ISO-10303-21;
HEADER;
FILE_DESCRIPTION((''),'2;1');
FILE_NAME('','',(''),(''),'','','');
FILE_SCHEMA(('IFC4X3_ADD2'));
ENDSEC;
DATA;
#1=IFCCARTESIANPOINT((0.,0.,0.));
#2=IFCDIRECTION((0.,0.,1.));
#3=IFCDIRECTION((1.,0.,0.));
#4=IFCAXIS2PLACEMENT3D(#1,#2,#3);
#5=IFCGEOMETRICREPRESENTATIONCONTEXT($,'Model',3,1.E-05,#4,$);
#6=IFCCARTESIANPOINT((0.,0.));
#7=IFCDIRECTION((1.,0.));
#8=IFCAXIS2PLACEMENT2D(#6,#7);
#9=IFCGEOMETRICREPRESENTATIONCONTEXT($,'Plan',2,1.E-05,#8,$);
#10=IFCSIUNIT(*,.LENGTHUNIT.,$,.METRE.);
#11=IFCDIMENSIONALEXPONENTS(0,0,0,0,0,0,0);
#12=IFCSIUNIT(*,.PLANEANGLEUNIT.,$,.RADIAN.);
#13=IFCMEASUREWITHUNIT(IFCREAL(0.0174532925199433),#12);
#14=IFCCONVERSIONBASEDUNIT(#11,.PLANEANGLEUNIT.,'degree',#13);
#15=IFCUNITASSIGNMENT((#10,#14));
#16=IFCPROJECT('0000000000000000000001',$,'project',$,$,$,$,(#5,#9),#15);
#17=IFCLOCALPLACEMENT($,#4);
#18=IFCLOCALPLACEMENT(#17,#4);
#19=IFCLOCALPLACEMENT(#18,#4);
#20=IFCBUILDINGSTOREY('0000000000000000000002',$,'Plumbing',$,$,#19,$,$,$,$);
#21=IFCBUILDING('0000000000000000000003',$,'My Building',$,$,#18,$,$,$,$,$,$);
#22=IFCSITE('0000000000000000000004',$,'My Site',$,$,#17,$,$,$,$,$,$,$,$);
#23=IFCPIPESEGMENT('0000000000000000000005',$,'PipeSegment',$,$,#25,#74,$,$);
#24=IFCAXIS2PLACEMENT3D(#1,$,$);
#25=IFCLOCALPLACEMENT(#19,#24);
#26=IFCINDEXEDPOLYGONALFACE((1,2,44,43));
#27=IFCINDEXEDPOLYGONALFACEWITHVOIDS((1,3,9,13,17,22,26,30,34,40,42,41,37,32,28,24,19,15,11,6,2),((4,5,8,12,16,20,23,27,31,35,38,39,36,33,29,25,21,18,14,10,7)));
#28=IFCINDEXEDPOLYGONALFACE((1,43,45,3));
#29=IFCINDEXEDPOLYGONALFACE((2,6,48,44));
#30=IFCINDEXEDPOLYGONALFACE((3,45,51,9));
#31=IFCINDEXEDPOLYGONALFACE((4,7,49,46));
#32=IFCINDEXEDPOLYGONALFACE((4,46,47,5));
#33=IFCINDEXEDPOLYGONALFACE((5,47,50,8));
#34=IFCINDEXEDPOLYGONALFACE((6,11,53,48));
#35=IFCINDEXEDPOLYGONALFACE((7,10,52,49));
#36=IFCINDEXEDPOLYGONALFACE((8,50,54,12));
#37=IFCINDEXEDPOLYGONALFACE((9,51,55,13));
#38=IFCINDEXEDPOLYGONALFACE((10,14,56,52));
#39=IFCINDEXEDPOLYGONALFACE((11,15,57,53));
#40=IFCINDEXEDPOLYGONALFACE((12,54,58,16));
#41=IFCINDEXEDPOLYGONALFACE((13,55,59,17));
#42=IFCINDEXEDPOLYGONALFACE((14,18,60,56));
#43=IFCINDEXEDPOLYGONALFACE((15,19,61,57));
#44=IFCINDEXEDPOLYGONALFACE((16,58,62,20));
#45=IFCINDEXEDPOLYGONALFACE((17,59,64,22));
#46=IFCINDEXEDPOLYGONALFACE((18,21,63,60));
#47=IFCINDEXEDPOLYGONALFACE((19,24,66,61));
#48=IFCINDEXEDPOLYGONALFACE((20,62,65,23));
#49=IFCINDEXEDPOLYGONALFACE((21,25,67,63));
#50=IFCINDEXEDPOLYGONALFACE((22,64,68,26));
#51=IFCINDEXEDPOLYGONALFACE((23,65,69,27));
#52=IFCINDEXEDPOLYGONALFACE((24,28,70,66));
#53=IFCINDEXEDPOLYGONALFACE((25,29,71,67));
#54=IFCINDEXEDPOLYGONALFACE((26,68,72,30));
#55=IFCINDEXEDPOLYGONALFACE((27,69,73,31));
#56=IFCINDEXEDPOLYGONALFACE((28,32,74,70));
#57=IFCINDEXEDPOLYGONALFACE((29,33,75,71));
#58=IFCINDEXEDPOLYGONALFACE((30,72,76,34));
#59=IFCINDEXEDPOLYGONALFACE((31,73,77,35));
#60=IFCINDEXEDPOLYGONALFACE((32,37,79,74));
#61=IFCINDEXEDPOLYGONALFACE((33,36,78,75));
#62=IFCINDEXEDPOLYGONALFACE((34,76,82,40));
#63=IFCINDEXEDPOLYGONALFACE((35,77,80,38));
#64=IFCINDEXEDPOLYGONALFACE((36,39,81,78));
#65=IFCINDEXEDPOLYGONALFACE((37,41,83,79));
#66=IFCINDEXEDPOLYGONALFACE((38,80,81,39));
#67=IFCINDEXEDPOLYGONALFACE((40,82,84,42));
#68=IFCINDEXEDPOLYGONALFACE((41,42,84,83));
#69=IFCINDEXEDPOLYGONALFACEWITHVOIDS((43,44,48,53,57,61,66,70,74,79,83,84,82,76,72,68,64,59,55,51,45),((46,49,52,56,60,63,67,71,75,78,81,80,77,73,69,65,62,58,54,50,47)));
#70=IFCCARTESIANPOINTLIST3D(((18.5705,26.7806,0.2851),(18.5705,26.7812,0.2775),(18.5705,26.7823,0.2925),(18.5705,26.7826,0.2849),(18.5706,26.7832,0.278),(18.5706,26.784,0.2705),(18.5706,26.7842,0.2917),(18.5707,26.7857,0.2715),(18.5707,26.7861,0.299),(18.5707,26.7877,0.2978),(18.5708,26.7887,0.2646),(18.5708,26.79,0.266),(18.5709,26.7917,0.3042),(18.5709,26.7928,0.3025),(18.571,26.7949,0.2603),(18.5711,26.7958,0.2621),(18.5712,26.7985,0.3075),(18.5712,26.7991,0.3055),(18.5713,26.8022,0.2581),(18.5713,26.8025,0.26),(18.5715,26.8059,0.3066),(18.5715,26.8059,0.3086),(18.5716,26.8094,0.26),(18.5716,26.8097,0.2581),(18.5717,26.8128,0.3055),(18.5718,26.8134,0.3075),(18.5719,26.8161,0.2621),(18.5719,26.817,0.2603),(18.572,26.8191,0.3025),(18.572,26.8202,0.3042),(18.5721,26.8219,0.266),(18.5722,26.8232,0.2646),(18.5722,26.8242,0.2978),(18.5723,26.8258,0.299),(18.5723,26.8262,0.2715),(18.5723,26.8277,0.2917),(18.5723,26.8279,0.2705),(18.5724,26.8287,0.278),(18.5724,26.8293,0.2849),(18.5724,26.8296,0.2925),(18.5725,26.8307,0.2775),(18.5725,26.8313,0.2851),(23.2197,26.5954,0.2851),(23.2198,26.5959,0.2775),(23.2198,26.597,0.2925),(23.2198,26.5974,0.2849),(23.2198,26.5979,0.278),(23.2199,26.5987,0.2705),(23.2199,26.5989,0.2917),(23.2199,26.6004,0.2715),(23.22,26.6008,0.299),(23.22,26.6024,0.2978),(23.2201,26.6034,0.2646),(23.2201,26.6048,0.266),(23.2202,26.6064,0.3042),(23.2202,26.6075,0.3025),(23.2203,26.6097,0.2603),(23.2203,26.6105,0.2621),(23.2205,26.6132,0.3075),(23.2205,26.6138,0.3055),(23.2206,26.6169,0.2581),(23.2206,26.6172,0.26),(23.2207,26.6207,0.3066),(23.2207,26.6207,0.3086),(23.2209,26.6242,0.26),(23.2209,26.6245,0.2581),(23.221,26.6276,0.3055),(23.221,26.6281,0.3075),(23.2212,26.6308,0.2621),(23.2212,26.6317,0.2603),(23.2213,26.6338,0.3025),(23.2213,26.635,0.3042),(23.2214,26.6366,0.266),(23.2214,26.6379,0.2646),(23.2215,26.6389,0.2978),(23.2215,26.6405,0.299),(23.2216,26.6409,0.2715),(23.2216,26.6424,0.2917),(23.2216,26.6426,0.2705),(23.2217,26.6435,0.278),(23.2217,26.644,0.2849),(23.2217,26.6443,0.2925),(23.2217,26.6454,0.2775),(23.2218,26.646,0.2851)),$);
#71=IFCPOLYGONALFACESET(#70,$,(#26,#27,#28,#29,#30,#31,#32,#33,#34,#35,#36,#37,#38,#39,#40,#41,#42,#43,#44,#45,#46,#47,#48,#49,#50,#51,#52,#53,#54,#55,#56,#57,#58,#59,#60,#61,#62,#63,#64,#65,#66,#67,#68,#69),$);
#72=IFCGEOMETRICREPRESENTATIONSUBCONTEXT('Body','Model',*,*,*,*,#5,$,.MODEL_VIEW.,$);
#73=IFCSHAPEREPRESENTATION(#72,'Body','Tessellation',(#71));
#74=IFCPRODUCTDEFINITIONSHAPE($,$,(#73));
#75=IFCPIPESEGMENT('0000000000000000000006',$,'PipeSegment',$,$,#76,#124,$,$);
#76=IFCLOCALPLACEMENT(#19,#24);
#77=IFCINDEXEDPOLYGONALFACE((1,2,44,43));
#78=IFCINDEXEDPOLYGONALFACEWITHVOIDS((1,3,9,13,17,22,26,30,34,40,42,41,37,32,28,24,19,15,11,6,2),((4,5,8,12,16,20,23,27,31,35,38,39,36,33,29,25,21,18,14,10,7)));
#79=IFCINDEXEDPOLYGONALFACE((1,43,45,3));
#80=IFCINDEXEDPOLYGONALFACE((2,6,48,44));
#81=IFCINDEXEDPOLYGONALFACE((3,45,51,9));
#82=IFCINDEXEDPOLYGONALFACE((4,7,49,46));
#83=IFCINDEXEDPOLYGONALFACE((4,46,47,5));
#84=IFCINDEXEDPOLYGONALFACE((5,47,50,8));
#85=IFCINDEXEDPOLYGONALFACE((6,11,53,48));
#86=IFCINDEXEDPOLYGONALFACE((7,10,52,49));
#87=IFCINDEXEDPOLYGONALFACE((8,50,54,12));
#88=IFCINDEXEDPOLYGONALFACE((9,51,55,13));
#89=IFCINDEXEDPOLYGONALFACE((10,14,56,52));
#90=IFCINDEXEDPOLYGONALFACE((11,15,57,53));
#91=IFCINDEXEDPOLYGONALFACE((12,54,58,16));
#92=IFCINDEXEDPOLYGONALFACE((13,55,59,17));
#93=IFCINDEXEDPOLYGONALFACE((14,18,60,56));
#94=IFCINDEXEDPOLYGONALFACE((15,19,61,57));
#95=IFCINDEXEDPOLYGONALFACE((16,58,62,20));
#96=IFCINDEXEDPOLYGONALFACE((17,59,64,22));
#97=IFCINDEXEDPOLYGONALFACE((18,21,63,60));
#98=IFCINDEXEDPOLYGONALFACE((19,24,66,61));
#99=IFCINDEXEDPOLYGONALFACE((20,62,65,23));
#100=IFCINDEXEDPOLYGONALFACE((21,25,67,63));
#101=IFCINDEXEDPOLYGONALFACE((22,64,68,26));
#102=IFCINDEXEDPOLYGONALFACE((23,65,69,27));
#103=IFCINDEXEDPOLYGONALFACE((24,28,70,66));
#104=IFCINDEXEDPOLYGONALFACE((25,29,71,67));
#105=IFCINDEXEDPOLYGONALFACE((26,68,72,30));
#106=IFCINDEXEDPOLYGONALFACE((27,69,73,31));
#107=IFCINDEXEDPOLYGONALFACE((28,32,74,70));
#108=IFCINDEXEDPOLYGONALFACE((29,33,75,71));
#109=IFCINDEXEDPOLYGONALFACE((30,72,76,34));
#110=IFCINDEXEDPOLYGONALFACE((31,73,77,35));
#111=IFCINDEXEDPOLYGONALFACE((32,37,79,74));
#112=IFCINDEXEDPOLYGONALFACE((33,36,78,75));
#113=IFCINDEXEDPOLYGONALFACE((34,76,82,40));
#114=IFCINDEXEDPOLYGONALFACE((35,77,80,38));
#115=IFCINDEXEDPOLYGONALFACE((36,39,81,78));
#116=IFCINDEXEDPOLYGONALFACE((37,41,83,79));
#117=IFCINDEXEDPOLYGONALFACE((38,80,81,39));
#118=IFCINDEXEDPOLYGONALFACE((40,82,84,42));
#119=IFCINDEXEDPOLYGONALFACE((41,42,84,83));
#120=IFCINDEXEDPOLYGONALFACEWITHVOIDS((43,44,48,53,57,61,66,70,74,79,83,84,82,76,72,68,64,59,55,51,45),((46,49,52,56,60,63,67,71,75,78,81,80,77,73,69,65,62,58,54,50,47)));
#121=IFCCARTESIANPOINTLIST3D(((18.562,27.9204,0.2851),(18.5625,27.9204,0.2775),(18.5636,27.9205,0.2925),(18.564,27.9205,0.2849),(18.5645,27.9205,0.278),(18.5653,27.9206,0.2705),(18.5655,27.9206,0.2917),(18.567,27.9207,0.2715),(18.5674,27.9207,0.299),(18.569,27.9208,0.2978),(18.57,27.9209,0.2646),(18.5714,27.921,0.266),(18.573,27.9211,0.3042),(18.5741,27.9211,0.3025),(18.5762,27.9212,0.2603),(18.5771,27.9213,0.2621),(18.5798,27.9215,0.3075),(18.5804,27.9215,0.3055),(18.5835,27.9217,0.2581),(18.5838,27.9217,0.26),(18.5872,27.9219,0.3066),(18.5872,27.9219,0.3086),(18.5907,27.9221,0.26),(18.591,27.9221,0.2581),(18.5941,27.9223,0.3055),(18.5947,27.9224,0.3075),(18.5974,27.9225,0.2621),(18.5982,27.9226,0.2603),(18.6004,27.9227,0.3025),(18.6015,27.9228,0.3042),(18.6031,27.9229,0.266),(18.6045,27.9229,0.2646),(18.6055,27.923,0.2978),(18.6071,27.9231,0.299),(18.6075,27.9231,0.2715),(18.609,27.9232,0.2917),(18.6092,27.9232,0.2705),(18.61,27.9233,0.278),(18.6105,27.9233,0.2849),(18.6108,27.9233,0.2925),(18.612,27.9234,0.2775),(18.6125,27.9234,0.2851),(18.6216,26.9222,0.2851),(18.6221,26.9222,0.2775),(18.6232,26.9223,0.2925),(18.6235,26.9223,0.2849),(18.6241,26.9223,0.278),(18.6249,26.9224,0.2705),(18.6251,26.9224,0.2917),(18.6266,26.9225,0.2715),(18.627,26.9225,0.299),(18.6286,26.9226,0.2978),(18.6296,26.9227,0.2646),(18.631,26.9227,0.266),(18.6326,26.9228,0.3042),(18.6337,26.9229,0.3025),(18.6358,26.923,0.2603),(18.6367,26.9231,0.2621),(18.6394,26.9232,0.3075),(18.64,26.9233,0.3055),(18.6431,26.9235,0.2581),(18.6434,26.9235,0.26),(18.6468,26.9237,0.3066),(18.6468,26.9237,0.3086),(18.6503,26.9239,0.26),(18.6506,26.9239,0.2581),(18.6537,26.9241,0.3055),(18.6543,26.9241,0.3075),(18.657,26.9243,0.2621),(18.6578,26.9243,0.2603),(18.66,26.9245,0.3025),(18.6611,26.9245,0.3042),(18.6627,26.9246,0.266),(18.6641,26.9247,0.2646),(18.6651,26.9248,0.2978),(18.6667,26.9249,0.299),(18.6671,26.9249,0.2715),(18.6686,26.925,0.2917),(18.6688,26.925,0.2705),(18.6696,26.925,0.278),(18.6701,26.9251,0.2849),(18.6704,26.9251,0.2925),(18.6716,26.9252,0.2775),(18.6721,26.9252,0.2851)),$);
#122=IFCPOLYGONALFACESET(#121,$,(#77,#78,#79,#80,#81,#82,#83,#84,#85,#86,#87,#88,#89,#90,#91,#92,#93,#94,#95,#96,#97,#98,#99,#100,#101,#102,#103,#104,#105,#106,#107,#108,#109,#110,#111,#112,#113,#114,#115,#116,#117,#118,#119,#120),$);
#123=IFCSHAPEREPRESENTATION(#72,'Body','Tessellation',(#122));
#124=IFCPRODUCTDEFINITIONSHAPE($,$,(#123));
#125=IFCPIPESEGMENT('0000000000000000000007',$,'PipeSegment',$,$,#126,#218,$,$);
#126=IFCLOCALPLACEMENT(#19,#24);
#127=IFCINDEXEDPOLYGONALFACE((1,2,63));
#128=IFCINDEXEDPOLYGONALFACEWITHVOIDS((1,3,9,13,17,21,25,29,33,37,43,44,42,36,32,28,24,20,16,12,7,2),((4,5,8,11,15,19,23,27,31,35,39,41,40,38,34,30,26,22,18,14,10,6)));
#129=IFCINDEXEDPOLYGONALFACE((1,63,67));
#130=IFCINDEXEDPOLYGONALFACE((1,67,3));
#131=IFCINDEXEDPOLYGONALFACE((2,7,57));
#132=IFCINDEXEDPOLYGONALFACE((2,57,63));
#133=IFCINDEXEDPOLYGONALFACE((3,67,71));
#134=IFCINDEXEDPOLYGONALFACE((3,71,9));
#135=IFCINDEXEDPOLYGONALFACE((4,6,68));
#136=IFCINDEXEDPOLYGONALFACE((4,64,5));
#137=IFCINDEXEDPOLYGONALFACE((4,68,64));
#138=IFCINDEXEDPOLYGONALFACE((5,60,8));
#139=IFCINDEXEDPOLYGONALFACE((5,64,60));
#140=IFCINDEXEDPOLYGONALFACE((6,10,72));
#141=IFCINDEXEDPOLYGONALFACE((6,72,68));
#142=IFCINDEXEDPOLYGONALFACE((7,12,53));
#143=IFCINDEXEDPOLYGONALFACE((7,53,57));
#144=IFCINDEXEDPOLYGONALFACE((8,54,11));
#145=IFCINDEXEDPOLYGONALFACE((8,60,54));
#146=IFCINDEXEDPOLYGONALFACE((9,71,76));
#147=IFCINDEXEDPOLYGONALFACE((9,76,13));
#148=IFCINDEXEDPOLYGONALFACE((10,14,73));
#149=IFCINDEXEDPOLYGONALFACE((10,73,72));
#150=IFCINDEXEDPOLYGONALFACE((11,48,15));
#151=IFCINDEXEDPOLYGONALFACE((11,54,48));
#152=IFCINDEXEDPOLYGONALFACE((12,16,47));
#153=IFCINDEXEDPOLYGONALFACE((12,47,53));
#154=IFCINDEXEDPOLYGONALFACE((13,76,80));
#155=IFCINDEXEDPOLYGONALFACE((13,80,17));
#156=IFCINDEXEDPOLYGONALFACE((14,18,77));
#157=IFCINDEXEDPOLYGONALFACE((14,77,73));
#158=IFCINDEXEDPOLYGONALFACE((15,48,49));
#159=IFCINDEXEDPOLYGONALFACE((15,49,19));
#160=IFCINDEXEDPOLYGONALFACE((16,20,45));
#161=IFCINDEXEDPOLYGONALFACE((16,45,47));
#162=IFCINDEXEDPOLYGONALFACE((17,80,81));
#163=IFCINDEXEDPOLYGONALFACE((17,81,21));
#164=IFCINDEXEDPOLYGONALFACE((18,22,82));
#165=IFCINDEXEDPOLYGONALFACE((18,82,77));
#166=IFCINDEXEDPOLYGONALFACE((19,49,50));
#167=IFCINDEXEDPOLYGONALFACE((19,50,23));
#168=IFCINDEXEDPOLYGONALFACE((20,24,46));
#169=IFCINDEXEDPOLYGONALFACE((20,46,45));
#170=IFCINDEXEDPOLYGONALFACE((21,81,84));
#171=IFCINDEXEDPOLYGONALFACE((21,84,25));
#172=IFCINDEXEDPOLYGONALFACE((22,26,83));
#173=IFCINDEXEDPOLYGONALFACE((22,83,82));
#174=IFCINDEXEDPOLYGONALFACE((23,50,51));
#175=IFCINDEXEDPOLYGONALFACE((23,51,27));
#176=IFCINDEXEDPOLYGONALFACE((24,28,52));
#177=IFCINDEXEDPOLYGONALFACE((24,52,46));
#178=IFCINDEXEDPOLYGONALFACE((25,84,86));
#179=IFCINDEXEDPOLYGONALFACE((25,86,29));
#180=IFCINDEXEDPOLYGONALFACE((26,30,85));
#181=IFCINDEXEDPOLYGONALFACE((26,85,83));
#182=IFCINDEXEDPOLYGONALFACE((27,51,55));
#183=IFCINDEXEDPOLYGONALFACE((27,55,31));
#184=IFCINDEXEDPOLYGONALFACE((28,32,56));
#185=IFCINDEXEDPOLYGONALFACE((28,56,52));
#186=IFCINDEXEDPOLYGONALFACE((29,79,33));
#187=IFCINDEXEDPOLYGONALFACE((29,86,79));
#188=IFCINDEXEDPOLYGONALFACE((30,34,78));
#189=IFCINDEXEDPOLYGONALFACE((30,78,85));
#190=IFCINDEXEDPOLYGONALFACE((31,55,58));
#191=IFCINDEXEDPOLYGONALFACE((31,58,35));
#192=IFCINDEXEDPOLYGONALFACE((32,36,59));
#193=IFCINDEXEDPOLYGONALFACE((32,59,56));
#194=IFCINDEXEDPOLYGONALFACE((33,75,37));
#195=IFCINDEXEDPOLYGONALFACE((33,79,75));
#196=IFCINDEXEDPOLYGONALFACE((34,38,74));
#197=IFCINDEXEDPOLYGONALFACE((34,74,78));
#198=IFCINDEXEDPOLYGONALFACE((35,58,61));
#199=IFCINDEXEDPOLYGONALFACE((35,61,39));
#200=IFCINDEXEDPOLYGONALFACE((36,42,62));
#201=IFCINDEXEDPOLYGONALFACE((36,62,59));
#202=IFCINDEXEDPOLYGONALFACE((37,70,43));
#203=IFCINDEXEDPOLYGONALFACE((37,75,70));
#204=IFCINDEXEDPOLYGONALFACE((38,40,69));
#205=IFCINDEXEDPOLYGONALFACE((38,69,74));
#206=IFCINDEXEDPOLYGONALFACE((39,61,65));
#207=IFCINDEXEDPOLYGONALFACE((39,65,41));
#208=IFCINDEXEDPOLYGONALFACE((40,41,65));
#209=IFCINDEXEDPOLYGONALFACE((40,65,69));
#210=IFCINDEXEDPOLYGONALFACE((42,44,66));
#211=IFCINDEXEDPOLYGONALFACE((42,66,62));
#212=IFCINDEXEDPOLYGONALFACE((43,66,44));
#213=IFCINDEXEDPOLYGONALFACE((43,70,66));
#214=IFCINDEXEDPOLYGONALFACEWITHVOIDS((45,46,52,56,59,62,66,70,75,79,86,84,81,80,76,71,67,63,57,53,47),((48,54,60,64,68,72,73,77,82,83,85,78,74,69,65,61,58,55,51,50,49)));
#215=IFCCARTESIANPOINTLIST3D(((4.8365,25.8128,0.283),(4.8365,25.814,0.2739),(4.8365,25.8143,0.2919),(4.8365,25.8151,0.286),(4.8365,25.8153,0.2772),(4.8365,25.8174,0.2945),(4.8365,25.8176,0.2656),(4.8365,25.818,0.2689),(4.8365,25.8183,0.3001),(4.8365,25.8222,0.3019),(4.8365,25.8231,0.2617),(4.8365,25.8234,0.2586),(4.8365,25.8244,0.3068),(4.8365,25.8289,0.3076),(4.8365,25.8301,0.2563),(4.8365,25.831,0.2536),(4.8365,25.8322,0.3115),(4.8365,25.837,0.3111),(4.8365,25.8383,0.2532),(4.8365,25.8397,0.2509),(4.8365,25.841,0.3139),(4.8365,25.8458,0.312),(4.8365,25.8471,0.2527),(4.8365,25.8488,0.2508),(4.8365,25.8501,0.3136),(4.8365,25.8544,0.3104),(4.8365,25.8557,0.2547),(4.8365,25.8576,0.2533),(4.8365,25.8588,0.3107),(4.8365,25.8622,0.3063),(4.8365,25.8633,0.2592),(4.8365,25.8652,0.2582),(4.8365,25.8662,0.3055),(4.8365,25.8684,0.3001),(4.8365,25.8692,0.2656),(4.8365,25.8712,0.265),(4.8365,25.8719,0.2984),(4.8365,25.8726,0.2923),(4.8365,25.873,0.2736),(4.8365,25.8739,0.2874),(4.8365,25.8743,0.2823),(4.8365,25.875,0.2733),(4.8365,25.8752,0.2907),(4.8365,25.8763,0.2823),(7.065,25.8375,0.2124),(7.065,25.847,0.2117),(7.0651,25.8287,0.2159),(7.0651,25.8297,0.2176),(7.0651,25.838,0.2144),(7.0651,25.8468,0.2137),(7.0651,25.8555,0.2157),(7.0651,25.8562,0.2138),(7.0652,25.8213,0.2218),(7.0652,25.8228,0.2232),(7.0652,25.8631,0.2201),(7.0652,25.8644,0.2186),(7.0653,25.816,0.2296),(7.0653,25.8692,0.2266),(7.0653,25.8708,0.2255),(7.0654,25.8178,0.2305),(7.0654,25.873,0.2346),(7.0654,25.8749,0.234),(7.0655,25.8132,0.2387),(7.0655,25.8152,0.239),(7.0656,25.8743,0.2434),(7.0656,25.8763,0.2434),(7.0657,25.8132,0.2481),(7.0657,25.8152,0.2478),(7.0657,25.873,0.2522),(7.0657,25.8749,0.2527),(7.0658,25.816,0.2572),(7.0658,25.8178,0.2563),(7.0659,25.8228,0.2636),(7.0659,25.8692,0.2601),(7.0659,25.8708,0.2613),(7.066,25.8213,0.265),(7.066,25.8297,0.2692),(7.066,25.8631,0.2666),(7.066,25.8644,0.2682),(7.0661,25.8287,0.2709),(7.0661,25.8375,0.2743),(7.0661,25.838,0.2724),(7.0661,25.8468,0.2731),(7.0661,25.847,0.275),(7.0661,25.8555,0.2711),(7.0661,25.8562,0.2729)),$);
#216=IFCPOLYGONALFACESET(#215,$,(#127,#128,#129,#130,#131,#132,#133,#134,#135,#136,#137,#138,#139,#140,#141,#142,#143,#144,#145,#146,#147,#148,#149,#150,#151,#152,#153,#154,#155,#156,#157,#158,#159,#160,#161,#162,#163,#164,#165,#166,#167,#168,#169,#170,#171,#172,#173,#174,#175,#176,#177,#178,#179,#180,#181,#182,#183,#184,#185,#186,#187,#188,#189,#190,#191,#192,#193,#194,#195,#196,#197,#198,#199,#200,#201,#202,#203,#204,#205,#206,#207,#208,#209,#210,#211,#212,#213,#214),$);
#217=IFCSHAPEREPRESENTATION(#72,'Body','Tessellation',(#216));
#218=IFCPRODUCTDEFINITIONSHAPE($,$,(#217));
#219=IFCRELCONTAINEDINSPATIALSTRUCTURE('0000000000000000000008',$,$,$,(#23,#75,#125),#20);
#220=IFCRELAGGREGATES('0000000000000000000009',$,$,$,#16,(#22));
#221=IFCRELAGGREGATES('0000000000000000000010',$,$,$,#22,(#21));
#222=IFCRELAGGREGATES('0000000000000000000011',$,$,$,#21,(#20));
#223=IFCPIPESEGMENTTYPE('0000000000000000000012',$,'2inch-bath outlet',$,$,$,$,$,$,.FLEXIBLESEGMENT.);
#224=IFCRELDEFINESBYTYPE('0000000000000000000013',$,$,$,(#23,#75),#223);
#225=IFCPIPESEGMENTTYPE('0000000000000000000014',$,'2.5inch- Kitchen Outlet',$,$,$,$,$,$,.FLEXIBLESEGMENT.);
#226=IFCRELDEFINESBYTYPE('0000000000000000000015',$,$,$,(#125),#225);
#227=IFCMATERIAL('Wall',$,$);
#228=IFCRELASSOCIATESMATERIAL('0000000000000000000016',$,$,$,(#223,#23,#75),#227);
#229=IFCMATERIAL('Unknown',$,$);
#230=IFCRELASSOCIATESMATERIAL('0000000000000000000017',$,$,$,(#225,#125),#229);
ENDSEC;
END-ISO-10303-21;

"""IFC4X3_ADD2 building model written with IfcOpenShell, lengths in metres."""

from ifc_helpers import new_model, entity, si_unit, converted_unit, frame, origin_with_axes, origin_2d_with_axis, place, context, subcontext, project, spatial, hollow_circle, extrude, clip, halfspace, material, material_profile, profile_set, profile_usage, type_object, element, save


model = new_model("IFC4X3_ADD2")

# Units and contexts
model_context = context("Model", 3, precision=1e-05, world=origin_with_axes())
plan_context = context("Plan", 2, precision=1e-05, world=origin_2d_with_axis())
body_context = subcontext(model_context, "Body", "Model", "MODEL_VIEW")
ifc_project = project(units=[si_unit("LENGTHUNIT", "METRE"), converted_unit("PLANEANGLEUNIT", "degree", entity("IfcReal", 0.0174532925199433), si_unit("PLANEANGLEUNIT", "RADIAN"), dimensions=[0, 0, 0, 0, 0, 0, 0])], contexts=[model_context, plan_context])

# Site, building, storey
site_placement = place(None, origin_with_axes())
site = spatial("IfcSite", under=ifc_project, at=site_placement, Name="My Site")
building_placement = place(site_placement, origin_with_axes())
building = spatial("IfcBuilding", under=site, at=building_placement, Name="My Building")
storey_placement = place(building_placement, origin_with_axes())
storey = spatial("IfcBuildingStorey", under=building, at=storey_placement, Name="Plumbing")

# Pipe segments
ifc_material_1 = material(Name="Unknown")
ifc_material_2 = material(Name="Wall")
ifc_material_profile_1 = material_profile(ifc_material_2, hollow_circle(Radius=0.0254, WallThickness=0.002))
ifc_profile_set_1 = profile_set([ifc_material_profile_1], Name="graywater")
ifc_material_profile_2 = material_profile(ifc_material_2, hollow_circle(Radius=0.0254, WallThickness=0.002))
ifc_profile_set_2 = profile_set([ifc_material_profile_2], Name="graywater")
pipe_segment_type_1 = type_object("IfcPipeSegmentType", Name="2inch-bath outlet", PredefinedType="FLEXIBLESEGMENT", material=ifc_profile_set_2)
ifc_profile_usage_1 = profile_usage(ifc_profile_set_1)
pipe_segment_1_placement = place(storey_placement, frame((23.2207, 26.6207, 0.2832), z_axis=(-0.999207, 0.039819, 0.0), x_axis=(0.0, 0.0, 1.0)))
element("IfcPipeSegment", 1, at=pipe_segment_1_placement, inside=storey, type_object=pipe_segment_type_1, material=ifc_profile_usage_1, Name="PipeSegment", context=body_context, shape_type="SweptSolid", body=[
    extrude(hollow_circle(Radius=0.0254, WallThickness=0.002), origin_with_axes(), (0.0, 0.0, 1.0), 4.653),
])
ifc_profile_usage_2 = profile_usage(ifc_profile_set_1)
pipe_segment_2_placement = place(storey_placement, frame((18.6468, 26.9237, 0.2832), z_axis=(-0.059597, 0.998223, 0.0), x_axis=(0.000001, 0.0, 1.0)))
element("IfcPipeSegment", 2, at=pipe_segment_2_placement, inside=storey, type_object=pipe_segment_type_1, material=ifc_profile_usage_2, Name="PipeSegment", context=body_context, shape_type="SweptSolid", body=[
    extrude(hollow_circle(Radius=0.0254, WallThickness=0.002), origin_with_axes(), (0.0, 0.0, 1.0), 1.0),
])
ifc_material_profile_3 = material_profile(ifc_material_1, hollow_circle(Radius=0.0318, WallThickness=0.002))
ifc_profile_set_3 = profile_set([ifc_material_profile_3], Name="kitchenwater")
ifc_material_profile_4 = material_profile(ifc_material_1, hollow_circle(Radius=0.0318, WallThickness=0.002))
ifc_profile_set_4 = profile_set([ifc_material_profile_4], Name="kitchenwater")
pipe_segment_type_2 = type_object("IfcPipeSegmentType", Name="2.5inch- Kitchen Outlet", PredefinedType="FLEXIBLESEGMENT", material=ifc_profile_set_4)
ifc_profile_usage_3 = profile_usage(ifc_profile_set_3)
pipe_segment_3_placement = place(storey_placement, frame((4.773, 25.8446, 0.2834), z_axis=(0.999848, 0.0, -0.017452), x_axis=(0.0, 1.0, 0.0)))
element("IfcPipeSegment", 3, at=pipe_segment_3_placement, inside=storey, type_object=pipe_segment_type_2, material=ifc_profile_usage_3, Name="PipeSegment", context=body_context, shape_type="Clipping", body=[
    clip(extrude(hollow_circle(Radius=0.0318, WallThickness=0.002), origin_with_axes(), (0.0, 0.0, 1.0), 2.2929), halfspace(frame((0.0316, 0.0202, 0.0631), z_axis=(0.0, -0.017452, -0.999848), x_axis=(-1.0, -0.000003, 0.0)), False)),
])

save(model, "model.ifc")
